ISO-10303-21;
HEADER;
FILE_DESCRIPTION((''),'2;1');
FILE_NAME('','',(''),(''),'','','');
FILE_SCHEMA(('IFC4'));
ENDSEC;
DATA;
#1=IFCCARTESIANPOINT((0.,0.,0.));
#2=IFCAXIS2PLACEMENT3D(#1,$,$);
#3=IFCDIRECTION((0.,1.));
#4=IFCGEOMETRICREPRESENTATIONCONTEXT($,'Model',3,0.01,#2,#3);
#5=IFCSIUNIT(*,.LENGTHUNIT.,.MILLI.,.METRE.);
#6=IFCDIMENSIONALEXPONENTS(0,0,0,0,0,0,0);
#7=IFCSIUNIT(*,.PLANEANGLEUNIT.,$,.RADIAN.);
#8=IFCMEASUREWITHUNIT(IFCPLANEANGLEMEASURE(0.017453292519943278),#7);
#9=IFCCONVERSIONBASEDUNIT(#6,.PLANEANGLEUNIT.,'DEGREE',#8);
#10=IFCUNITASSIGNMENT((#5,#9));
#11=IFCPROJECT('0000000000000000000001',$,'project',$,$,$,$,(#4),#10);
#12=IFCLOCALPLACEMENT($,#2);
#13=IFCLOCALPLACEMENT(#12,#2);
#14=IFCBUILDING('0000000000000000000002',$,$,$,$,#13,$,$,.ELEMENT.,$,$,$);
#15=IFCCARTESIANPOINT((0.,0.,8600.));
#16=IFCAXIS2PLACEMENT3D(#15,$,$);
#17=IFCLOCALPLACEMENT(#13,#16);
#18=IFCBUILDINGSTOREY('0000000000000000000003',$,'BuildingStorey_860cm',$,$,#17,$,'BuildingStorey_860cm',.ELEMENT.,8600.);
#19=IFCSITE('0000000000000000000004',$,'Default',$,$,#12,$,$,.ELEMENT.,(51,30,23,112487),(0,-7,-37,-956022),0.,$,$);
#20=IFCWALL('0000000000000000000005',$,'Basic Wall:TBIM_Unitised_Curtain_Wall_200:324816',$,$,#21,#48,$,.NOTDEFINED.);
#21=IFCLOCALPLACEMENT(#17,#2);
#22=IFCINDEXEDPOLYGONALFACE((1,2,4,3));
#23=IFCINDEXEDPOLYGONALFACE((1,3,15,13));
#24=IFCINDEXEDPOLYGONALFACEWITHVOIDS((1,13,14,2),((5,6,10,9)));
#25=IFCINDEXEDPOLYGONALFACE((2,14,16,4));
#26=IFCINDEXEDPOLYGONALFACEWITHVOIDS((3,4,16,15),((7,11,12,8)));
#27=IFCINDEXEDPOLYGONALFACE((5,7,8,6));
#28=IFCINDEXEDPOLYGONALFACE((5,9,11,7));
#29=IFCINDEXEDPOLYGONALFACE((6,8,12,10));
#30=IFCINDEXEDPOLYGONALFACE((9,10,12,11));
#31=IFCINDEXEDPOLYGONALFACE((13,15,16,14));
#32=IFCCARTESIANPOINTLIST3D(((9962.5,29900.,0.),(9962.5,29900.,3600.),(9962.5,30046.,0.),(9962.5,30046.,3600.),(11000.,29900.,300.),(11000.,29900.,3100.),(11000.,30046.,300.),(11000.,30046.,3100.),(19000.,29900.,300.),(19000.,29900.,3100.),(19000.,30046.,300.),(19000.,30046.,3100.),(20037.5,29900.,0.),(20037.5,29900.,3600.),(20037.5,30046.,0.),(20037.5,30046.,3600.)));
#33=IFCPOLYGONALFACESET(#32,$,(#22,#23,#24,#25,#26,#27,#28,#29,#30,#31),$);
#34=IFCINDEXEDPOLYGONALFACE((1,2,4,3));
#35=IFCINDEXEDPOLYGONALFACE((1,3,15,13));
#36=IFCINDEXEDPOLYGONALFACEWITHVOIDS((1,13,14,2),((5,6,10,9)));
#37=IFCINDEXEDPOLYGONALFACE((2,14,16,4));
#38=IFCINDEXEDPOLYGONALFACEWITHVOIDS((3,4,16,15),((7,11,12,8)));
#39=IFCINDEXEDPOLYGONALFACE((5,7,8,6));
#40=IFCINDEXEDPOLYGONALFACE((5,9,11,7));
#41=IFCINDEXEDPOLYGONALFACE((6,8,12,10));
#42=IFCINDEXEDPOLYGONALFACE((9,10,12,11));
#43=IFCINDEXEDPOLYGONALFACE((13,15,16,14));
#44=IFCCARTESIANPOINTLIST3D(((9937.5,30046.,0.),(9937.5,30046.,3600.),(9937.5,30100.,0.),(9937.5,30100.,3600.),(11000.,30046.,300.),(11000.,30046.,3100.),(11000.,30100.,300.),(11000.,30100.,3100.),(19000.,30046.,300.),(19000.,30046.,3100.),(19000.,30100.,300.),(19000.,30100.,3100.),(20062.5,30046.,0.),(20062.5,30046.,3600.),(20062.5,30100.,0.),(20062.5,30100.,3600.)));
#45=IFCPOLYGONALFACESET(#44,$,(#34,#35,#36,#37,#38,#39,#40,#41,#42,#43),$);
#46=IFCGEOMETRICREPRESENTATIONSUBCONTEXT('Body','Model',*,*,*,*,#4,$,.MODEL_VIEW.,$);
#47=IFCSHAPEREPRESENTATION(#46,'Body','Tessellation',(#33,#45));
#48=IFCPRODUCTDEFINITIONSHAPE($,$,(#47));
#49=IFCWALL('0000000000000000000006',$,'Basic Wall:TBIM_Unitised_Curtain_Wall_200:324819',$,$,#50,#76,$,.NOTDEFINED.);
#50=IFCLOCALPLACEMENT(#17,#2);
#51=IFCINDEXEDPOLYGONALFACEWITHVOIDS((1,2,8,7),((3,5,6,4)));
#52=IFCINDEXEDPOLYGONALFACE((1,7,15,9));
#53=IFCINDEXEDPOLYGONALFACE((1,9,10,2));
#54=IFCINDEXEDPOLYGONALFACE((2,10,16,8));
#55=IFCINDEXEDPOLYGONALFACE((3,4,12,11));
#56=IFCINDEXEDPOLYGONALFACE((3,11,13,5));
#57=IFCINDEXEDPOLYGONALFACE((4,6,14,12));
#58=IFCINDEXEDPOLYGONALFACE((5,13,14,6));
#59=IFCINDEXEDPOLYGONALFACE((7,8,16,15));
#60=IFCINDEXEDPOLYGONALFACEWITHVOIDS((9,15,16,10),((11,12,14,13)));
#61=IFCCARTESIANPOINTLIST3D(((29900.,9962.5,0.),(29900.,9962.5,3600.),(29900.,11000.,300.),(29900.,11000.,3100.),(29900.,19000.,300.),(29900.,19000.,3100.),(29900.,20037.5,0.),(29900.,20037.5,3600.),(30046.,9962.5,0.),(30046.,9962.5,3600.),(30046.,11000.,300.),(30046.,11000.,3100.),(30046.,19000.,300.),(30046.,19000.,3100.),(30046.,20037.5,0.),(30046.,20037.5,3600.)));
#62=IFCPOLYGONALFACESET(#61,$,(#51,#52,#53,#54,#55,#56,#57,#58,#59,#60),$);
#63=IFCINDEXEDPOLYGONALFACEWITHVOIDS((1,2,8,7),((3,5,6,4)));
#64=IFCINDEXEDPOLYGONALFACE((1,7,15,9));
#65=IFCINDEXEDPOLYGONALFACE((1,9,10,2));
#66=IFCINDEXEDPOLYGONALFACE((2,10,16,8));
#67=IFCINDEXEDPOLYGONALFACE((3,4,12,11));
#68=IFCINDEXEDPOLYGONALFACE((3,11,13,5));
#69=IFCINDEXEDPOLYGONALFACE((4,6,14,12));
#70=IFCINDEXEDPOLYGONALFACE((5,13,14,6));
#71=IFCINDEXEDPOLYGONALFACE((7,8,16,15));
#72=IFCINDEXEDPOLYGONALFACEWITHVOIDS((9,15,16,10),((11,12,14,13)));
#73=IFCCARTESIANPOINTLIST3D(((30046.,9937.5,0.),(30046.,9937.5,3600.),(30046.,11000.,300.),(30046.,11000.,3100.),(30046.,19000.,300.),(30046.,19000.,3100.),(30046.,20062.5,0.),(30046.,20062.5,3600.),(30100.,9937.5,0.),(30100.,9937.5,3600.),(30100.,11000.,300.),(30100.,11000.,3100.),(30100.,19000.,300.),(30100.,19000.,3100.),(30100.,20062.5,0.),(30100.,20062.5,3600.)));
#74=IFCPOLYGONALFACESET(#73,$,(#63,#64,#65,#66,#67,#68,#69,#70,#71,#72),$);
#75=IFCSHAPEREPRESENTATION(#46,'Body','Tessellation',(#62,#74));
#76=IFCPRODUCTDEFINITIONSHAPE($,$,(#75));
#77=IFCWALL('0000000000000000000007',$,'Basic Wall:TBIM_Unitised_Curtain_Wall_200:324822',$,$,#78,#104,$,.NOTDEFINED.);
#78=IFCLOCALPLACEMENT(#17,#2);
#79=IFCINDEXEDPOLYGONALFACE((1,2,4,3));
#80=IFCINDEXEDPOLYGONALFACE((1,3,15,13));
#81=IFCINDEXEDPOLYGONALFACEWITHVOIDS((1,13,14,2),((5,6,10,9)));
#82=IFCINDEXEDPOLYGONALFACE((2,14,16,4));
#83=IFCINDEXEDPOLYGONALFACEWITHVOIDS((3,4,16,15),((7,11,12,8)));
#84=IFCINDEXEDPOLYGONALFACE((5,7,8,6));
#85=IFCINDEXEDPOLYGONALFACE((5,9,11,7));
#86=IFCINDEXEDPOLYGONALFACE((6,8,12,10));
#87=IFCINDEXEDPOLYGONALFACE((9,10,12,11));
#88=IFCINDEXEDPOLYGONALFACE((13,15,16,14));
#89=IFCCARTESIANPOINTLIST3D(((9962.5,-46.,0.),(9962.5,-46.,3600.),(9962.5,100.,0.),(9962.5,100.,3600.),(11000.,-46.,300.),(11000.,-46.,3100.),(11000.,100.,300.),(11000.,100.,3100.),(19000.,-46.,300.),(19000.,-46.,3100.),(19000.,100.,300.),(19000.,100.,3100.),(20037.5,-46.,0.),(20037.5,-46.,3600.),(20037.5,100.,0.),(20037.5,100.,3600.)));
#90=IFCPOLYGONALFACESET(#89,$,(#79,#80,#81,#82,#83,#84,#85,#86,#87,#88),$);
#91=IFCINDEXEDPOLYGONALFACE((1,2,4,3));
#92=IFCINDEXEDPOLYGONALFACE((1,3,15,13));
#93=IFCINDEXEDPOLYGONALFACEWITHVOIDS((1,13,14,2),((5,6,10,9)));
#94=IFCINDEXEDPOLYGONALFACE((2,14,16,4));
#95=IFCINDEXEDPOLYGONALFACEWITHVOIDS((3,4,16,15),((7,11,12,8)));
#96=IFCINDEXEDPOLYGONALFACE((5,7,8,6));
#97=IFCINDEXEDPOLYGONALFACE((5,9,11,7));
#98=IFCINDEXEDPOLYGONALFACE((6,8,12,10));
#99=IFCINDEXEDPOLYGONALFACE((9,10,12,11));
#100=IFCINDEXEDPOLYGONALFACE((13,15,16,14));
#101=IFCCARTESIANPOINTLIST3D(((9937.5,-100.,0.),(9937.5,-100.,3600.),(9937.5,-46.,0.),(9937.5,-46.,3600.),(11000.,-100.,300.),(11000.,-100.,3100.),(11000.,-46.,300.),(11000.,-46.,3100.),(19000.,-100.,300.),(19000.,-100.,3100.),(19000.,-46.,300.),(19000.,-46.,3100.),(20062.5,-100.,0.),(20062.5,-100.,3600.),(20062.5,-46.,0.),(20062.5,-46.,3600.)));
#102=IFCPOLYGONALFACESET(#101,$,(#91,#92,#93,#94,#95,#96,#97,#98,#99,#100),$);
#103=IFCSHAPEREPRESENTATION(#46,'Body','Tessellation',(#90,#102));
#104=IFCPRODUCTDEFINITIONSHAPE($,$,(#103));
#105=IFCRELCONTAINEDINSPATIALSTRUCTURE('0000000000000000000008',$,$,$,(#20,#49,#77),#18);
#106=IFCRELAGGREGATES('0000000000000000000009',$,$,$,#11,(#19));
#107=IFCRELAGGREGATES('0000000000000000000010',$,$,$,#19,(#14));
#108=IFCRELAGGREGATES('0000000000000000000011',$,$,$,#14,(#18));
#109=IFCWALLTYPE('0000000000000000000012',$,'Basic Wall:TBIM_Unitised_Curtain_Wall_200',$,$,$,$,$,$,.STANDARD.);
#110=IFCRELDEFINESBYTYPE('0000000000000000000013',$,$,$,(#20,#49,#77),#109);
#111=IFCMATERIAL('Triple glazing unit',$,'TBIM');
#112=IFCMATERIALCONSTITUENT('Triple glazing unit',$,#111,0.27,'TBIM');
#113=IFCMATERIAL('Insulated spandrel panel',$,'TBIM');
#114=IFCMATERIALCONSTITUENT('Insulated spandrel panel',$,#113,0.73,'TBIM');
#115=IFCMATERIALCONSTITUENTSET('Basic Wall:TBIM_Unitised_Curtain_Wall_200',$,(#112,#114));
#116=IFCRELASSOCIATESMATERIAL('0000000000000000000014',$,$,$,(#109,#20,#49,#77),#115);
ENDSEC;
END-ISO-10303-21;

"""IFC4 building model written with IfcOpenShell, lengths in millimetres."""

from ifc_helpers import new_model, entity, si_unit, converted_unit, direction, frame, origin, place, context, subcontext, project, spatial, indexed_curve, outline, extrude, material, constituent, constituent_set, type_object, element, save


model = new_model("IFC4")

# Units and contexts
model_context = context("Model", 3, precision=0.01, world=origin(), true_north=direction((0.0, 1.0)))
body_context = subcontext(model_context, "Body", "Model", "MODEL_VIEW")
ifc_project = project(units=[si_unit("LENGTHUNIT", "METRE", prefix="MILLI"), converted_unit("PLANEANGLEUNIT", "DEGREE", entity("IfcPlaneAngleMeasure", 0.017453292519943278), si_unit("PLANEANGLEUNIT", "RADIAN"), dimensions=[0, 0, 0, 0, 0, 0, 0])], contexts=[model_context])

# Site, building, storey
site_placement = place(None, origin())
site = spatial("IfcSite", under=ifc_project, at=site_placement, Name="Default", CompositionType="ELEMENT", RefLatitude=(51, 30, 23, 112487), RefLongitude=(0, -7, -37, -956022), RefElevation=0.0)
building_placement = place(site_placement, origin())
building = spatial("IfcBuilding", under=site, at=building_placement, CompositionType="ELEMENT")
storey_placement = place(building_placement, frame((0.0, 0.0, 8600.0)))
storey = spatial("IfcBuildingStorey", under=building, at=storey_placement, Name="BuildingStorey_860cm", LongName="BuildingStorey_860cm", CompositionType="ELEMENT", Elevation=8600.0)

# Walls, openings
ifc_material_1 = material(Name="Triple glazing unit", Category="TBIM")
ifc_constituent_1 = constituent(ifc_material_1, Name="Triple glazing unit", Category="TBIM", fraction=0.27)
ifc_material_2 = material(Name="Insulated spandrel panel", Category="TBIM")
ifc_constituent_2 = constituent(ifc_material_2, Name="Insulated spandrel panel", Category="TBIM", fraction=0.73)
ifc_constituent_set_1 = constituent_set(constituents=[ifc_constituent_1, ifc_constituent_2], Name="Basic Wall:TBIM_Unitised_Curtain_Wall_200")
wall_type_1 = type_object("IfcWallType", Name="Basic Wall:TBIM_Unitised_Curtain_Wall_200", PredefinedType="STANDARD", material=ifc_constituent_set_1)
wall_1_placement = place(storey_placement, frame((9937.5, 30000.0, 0.0)))
wall_1 = element("IfcWall", 1, at=wall_1_placement, inside=storey, type_object=wall_type_1, material=ifc_constituent_set_1, Name="Basic Wall:TBIM_Unitised_Curtain_Wall_200:324816", PredefinedType="NOTDEFINED", context=body_context, shape_type="SweptSolid", body=[
    extrude(outline(indexed_curve([(-1800.0, -5037.5), (1800.0, -5037.5), (1800.0, -4937.5), (1800.0, 4937.5), (1800.0, 5037.5), (-1800.0, 5037.5), (-1800.0, 4937.5), (-1800.0, -4937.5), (-1800.0, -5037.5)], self_intersect=False), holes=[indexed_curve([(1300.0, -4000.0), (-1500.0, -4000.0), (-1500.0, 4000.0), (1300.0, 4000.0), (1300.0, -4000.0)], self_intersect=False)]), frame((5062.5, -100.0, 1800.0), z_axis=(0.0, 1.0, 0.0), x_axis=(0.0, 0.0, 1.0)), (0.0, 0.0, 1.0), 146.0),
    extrude(outline(indexed_curve([(-1800.0, -5062.5), (1800.0, -5062.5), (1800.0, 5062.5), (-1800.0, 5062.5), (-1800.0, -5062.5)], self_intersect=False), holes=[indexed_curve([(-1500.0, -4000.0), (-1500.0, 4000.0), (1300.0, 4000.0), (1300.0, -4000.0), (-1500.0, -4000.0)], self_intersect=False)]), frame((5062.5, 46.0, 1800.0), z_axis=(0.0, 1.0, 0.0), x_axis=(0.0, 0.0, 1.0)), (0.0, 0.0, 1.0), 54.0),
])
opening_1_placement = place(wall_1_placement, frame((1062.5, -100.0, 300.0)))
element("IfcOpeningElement", 2, at=opening_1_placement, cuts=wall_1, PredefinedType="OPENING", context=body_context, shape_type="SweptSolid", body=[
    extrude(outline(indexed_curve([(2800.0, 0.0), (2800.0, 8000.0), (0.0, 8000.0), (0.0, 0.0), (2800.0, 0.0)], self_intersect=False)), frame((0.0, 0.0, 0.0), z_axis=(0.0, 1.0, 0.0), x_axis=(0.0, 0.0, 1.0)), (0.0, 0.0, 1.0), 200.0),
])
wall_2_placement = place(storey_placement, frame((30000.0, 9937.5, 0.0), z_axis=(0.0, 0.0, 1.0), x_axis=(0.0, 1.0, 0.0)))
wall_2 = element("IfcWall", 3, at=wall_2_placement, inside=storey, type_object=wall_type_1, material=ifc_constituent_set_1, Name="Basic Wall:TBIM_Unitised_Curtain_Wall_200:324819", PredefinedType="NOTDEFINED", context=body_context, shape_type="SweptSolid", body=[
    extrude(outline(indexed_curve([(-5037.5, -1800.0), (-4937.5, -1800.0), (4937.5, -1800.0), (5037.5, -1800.0), (5037.5, 1800.0), (4937.5, 1800.0), (-4937.5, 1800.0), (-5037.5, 1800.0), (-5037.5, -1800.0)], self_intersect=False), holes=[indexed_curve([(-4000.0, 1300.0), (4000.0, 1300.0), (4000.0, -1500.0), (-4000.0, -1500.0), (-4000.0, 1300.0)], self_intersect=False)]), frame((5062.5, 100.0, 1800.0), z_axis=(0.0, -1.0, 0.0), x_axis=(1.0, 0.0, 0.0)), (0.0, 0.0, 1.0), 146.0),
    extrude(outline(indexed_curve([(-1800.0, -5062.5), (1800.0, -5062.5), (1800.0, 5062.5), (-1800.0, 5062.5), (-1800.0, -5062.5)], self_intersect=False), holes=[indexed_curve([(1300.0, 4000.0), (1300.0, -4000.0), (-1500.0, -4000.0), (-1500.0, 4000.0), (1300.0, 4000.0)], self_intersect=False)]), frame((5062.5, -46.0, 1800.0), z_axis=(0.0, -1.0, 0.0), x_axis=(0.0, 0.0, 1.0)), (0.0, 0.0, 1.0), 54.0),
])
opening_2_placement = place(wall_2_placement, frame((1062.5, -100.0, 300.0)))
element("IfcOpeningElement", 4, at=opening_2_placement, cuts=wall_2, PredefinedType="OPENING", context=body_context, shape_type="SweptSolid", body=[
    extrude(outline(indexed_curve([(2800.0, 0.0), (2800.0, 8000.0), (0.0, 8000.0), (0.0, 0.0), (2800.0, 0.0)], self_intersect=False)), frame((0.0, 0.0, 0.0), z_axis=(0.0, 1.0, 0.0), x_axis=(0.0, 0.0, 1.0)), (0.0, 0.0, 1.0), 200.0),
])
wall_3_placement = place(storey_placement, frame((9937.5, 0.0, 0.0)))
wall_3 = element("IfcWall", 5, at=wall_3_placement, inside=storey, type_object=wall_type_1, material=ifc_constituent_set_1, Name="Basic Wall:TBIM_Unitised_Curtain_Wall_200:324822", PredefinedType="NOTDEFINED", context=body_context, shape_type="SweptSolid", body=[
    extrude(outline(indexed_curve([(-1800.0, -5037.5), (1800.0, -5037.5), (1800.0, 5037.5), (-1800.0, 5037.5), (-1800.0, -5037.5)], self_intersect=False), holes=[indexed_curve([(-1500.0, -4000.0), (-1500.0, 4000.0), (1300.0, 4000.0), (1300.0, -4000.0), (-1500.0, -4000.0)], self_intersect=False)]), frame((5062.5, -46.0, 1800.0), z_axis=(0.0, 1.0, 0.0), x_axis=(0.0, 0.0, 1.0)), (0.0, 0.0, 1.0), 146.0),
    extrude(outline(indexed_curve([(-1800.0, -5062.5), (1800.0, -5062.5), (1800.0, 5062.5), (-1800.0, 5062.5), (-1800.0, -5062.5)], self_intersect=False), holes=[indexed_curve([(1300.0, -4000.0), (-1500.0, -4000.0), (-1500.0, 4000.0), (1300.0, 4000.0), (1300.0, -4000.0)], self_intersect=False)]), frame((5062.5, -100.0, 1800.0), z_axis=(0.0, 1.0, 0.0), x_axis=(0.0, 0.0, 1.0)), (0.0, 0.0, 1.0), 54.0),
])
opening_3_placement = place(wall_3_placement, frame((1062.5, -100.0, 300.0)))
element("IfcOpeningElement", 6, at=opening_3_placement, cuts=wall_3, PredefinedType="OPENING", context=body_context, shape_type="SweptSolid", body=[
    extrude(outline(indexed_curve([(2800.0, 0.0), (2800.0, 8000.0), (0.0, 8000.0), (0.0, 0.0), (2800.0, 0.0)], self_intersect=False)), frame((0.0, 0.0, 0.0), z_axis=(0.0, 1.0, 0.0), x_axis=(0.0, 0.0, 1.0)), (0.0, 0.0, 1.0), 200.0),
])

save(model, "model.ifc")
